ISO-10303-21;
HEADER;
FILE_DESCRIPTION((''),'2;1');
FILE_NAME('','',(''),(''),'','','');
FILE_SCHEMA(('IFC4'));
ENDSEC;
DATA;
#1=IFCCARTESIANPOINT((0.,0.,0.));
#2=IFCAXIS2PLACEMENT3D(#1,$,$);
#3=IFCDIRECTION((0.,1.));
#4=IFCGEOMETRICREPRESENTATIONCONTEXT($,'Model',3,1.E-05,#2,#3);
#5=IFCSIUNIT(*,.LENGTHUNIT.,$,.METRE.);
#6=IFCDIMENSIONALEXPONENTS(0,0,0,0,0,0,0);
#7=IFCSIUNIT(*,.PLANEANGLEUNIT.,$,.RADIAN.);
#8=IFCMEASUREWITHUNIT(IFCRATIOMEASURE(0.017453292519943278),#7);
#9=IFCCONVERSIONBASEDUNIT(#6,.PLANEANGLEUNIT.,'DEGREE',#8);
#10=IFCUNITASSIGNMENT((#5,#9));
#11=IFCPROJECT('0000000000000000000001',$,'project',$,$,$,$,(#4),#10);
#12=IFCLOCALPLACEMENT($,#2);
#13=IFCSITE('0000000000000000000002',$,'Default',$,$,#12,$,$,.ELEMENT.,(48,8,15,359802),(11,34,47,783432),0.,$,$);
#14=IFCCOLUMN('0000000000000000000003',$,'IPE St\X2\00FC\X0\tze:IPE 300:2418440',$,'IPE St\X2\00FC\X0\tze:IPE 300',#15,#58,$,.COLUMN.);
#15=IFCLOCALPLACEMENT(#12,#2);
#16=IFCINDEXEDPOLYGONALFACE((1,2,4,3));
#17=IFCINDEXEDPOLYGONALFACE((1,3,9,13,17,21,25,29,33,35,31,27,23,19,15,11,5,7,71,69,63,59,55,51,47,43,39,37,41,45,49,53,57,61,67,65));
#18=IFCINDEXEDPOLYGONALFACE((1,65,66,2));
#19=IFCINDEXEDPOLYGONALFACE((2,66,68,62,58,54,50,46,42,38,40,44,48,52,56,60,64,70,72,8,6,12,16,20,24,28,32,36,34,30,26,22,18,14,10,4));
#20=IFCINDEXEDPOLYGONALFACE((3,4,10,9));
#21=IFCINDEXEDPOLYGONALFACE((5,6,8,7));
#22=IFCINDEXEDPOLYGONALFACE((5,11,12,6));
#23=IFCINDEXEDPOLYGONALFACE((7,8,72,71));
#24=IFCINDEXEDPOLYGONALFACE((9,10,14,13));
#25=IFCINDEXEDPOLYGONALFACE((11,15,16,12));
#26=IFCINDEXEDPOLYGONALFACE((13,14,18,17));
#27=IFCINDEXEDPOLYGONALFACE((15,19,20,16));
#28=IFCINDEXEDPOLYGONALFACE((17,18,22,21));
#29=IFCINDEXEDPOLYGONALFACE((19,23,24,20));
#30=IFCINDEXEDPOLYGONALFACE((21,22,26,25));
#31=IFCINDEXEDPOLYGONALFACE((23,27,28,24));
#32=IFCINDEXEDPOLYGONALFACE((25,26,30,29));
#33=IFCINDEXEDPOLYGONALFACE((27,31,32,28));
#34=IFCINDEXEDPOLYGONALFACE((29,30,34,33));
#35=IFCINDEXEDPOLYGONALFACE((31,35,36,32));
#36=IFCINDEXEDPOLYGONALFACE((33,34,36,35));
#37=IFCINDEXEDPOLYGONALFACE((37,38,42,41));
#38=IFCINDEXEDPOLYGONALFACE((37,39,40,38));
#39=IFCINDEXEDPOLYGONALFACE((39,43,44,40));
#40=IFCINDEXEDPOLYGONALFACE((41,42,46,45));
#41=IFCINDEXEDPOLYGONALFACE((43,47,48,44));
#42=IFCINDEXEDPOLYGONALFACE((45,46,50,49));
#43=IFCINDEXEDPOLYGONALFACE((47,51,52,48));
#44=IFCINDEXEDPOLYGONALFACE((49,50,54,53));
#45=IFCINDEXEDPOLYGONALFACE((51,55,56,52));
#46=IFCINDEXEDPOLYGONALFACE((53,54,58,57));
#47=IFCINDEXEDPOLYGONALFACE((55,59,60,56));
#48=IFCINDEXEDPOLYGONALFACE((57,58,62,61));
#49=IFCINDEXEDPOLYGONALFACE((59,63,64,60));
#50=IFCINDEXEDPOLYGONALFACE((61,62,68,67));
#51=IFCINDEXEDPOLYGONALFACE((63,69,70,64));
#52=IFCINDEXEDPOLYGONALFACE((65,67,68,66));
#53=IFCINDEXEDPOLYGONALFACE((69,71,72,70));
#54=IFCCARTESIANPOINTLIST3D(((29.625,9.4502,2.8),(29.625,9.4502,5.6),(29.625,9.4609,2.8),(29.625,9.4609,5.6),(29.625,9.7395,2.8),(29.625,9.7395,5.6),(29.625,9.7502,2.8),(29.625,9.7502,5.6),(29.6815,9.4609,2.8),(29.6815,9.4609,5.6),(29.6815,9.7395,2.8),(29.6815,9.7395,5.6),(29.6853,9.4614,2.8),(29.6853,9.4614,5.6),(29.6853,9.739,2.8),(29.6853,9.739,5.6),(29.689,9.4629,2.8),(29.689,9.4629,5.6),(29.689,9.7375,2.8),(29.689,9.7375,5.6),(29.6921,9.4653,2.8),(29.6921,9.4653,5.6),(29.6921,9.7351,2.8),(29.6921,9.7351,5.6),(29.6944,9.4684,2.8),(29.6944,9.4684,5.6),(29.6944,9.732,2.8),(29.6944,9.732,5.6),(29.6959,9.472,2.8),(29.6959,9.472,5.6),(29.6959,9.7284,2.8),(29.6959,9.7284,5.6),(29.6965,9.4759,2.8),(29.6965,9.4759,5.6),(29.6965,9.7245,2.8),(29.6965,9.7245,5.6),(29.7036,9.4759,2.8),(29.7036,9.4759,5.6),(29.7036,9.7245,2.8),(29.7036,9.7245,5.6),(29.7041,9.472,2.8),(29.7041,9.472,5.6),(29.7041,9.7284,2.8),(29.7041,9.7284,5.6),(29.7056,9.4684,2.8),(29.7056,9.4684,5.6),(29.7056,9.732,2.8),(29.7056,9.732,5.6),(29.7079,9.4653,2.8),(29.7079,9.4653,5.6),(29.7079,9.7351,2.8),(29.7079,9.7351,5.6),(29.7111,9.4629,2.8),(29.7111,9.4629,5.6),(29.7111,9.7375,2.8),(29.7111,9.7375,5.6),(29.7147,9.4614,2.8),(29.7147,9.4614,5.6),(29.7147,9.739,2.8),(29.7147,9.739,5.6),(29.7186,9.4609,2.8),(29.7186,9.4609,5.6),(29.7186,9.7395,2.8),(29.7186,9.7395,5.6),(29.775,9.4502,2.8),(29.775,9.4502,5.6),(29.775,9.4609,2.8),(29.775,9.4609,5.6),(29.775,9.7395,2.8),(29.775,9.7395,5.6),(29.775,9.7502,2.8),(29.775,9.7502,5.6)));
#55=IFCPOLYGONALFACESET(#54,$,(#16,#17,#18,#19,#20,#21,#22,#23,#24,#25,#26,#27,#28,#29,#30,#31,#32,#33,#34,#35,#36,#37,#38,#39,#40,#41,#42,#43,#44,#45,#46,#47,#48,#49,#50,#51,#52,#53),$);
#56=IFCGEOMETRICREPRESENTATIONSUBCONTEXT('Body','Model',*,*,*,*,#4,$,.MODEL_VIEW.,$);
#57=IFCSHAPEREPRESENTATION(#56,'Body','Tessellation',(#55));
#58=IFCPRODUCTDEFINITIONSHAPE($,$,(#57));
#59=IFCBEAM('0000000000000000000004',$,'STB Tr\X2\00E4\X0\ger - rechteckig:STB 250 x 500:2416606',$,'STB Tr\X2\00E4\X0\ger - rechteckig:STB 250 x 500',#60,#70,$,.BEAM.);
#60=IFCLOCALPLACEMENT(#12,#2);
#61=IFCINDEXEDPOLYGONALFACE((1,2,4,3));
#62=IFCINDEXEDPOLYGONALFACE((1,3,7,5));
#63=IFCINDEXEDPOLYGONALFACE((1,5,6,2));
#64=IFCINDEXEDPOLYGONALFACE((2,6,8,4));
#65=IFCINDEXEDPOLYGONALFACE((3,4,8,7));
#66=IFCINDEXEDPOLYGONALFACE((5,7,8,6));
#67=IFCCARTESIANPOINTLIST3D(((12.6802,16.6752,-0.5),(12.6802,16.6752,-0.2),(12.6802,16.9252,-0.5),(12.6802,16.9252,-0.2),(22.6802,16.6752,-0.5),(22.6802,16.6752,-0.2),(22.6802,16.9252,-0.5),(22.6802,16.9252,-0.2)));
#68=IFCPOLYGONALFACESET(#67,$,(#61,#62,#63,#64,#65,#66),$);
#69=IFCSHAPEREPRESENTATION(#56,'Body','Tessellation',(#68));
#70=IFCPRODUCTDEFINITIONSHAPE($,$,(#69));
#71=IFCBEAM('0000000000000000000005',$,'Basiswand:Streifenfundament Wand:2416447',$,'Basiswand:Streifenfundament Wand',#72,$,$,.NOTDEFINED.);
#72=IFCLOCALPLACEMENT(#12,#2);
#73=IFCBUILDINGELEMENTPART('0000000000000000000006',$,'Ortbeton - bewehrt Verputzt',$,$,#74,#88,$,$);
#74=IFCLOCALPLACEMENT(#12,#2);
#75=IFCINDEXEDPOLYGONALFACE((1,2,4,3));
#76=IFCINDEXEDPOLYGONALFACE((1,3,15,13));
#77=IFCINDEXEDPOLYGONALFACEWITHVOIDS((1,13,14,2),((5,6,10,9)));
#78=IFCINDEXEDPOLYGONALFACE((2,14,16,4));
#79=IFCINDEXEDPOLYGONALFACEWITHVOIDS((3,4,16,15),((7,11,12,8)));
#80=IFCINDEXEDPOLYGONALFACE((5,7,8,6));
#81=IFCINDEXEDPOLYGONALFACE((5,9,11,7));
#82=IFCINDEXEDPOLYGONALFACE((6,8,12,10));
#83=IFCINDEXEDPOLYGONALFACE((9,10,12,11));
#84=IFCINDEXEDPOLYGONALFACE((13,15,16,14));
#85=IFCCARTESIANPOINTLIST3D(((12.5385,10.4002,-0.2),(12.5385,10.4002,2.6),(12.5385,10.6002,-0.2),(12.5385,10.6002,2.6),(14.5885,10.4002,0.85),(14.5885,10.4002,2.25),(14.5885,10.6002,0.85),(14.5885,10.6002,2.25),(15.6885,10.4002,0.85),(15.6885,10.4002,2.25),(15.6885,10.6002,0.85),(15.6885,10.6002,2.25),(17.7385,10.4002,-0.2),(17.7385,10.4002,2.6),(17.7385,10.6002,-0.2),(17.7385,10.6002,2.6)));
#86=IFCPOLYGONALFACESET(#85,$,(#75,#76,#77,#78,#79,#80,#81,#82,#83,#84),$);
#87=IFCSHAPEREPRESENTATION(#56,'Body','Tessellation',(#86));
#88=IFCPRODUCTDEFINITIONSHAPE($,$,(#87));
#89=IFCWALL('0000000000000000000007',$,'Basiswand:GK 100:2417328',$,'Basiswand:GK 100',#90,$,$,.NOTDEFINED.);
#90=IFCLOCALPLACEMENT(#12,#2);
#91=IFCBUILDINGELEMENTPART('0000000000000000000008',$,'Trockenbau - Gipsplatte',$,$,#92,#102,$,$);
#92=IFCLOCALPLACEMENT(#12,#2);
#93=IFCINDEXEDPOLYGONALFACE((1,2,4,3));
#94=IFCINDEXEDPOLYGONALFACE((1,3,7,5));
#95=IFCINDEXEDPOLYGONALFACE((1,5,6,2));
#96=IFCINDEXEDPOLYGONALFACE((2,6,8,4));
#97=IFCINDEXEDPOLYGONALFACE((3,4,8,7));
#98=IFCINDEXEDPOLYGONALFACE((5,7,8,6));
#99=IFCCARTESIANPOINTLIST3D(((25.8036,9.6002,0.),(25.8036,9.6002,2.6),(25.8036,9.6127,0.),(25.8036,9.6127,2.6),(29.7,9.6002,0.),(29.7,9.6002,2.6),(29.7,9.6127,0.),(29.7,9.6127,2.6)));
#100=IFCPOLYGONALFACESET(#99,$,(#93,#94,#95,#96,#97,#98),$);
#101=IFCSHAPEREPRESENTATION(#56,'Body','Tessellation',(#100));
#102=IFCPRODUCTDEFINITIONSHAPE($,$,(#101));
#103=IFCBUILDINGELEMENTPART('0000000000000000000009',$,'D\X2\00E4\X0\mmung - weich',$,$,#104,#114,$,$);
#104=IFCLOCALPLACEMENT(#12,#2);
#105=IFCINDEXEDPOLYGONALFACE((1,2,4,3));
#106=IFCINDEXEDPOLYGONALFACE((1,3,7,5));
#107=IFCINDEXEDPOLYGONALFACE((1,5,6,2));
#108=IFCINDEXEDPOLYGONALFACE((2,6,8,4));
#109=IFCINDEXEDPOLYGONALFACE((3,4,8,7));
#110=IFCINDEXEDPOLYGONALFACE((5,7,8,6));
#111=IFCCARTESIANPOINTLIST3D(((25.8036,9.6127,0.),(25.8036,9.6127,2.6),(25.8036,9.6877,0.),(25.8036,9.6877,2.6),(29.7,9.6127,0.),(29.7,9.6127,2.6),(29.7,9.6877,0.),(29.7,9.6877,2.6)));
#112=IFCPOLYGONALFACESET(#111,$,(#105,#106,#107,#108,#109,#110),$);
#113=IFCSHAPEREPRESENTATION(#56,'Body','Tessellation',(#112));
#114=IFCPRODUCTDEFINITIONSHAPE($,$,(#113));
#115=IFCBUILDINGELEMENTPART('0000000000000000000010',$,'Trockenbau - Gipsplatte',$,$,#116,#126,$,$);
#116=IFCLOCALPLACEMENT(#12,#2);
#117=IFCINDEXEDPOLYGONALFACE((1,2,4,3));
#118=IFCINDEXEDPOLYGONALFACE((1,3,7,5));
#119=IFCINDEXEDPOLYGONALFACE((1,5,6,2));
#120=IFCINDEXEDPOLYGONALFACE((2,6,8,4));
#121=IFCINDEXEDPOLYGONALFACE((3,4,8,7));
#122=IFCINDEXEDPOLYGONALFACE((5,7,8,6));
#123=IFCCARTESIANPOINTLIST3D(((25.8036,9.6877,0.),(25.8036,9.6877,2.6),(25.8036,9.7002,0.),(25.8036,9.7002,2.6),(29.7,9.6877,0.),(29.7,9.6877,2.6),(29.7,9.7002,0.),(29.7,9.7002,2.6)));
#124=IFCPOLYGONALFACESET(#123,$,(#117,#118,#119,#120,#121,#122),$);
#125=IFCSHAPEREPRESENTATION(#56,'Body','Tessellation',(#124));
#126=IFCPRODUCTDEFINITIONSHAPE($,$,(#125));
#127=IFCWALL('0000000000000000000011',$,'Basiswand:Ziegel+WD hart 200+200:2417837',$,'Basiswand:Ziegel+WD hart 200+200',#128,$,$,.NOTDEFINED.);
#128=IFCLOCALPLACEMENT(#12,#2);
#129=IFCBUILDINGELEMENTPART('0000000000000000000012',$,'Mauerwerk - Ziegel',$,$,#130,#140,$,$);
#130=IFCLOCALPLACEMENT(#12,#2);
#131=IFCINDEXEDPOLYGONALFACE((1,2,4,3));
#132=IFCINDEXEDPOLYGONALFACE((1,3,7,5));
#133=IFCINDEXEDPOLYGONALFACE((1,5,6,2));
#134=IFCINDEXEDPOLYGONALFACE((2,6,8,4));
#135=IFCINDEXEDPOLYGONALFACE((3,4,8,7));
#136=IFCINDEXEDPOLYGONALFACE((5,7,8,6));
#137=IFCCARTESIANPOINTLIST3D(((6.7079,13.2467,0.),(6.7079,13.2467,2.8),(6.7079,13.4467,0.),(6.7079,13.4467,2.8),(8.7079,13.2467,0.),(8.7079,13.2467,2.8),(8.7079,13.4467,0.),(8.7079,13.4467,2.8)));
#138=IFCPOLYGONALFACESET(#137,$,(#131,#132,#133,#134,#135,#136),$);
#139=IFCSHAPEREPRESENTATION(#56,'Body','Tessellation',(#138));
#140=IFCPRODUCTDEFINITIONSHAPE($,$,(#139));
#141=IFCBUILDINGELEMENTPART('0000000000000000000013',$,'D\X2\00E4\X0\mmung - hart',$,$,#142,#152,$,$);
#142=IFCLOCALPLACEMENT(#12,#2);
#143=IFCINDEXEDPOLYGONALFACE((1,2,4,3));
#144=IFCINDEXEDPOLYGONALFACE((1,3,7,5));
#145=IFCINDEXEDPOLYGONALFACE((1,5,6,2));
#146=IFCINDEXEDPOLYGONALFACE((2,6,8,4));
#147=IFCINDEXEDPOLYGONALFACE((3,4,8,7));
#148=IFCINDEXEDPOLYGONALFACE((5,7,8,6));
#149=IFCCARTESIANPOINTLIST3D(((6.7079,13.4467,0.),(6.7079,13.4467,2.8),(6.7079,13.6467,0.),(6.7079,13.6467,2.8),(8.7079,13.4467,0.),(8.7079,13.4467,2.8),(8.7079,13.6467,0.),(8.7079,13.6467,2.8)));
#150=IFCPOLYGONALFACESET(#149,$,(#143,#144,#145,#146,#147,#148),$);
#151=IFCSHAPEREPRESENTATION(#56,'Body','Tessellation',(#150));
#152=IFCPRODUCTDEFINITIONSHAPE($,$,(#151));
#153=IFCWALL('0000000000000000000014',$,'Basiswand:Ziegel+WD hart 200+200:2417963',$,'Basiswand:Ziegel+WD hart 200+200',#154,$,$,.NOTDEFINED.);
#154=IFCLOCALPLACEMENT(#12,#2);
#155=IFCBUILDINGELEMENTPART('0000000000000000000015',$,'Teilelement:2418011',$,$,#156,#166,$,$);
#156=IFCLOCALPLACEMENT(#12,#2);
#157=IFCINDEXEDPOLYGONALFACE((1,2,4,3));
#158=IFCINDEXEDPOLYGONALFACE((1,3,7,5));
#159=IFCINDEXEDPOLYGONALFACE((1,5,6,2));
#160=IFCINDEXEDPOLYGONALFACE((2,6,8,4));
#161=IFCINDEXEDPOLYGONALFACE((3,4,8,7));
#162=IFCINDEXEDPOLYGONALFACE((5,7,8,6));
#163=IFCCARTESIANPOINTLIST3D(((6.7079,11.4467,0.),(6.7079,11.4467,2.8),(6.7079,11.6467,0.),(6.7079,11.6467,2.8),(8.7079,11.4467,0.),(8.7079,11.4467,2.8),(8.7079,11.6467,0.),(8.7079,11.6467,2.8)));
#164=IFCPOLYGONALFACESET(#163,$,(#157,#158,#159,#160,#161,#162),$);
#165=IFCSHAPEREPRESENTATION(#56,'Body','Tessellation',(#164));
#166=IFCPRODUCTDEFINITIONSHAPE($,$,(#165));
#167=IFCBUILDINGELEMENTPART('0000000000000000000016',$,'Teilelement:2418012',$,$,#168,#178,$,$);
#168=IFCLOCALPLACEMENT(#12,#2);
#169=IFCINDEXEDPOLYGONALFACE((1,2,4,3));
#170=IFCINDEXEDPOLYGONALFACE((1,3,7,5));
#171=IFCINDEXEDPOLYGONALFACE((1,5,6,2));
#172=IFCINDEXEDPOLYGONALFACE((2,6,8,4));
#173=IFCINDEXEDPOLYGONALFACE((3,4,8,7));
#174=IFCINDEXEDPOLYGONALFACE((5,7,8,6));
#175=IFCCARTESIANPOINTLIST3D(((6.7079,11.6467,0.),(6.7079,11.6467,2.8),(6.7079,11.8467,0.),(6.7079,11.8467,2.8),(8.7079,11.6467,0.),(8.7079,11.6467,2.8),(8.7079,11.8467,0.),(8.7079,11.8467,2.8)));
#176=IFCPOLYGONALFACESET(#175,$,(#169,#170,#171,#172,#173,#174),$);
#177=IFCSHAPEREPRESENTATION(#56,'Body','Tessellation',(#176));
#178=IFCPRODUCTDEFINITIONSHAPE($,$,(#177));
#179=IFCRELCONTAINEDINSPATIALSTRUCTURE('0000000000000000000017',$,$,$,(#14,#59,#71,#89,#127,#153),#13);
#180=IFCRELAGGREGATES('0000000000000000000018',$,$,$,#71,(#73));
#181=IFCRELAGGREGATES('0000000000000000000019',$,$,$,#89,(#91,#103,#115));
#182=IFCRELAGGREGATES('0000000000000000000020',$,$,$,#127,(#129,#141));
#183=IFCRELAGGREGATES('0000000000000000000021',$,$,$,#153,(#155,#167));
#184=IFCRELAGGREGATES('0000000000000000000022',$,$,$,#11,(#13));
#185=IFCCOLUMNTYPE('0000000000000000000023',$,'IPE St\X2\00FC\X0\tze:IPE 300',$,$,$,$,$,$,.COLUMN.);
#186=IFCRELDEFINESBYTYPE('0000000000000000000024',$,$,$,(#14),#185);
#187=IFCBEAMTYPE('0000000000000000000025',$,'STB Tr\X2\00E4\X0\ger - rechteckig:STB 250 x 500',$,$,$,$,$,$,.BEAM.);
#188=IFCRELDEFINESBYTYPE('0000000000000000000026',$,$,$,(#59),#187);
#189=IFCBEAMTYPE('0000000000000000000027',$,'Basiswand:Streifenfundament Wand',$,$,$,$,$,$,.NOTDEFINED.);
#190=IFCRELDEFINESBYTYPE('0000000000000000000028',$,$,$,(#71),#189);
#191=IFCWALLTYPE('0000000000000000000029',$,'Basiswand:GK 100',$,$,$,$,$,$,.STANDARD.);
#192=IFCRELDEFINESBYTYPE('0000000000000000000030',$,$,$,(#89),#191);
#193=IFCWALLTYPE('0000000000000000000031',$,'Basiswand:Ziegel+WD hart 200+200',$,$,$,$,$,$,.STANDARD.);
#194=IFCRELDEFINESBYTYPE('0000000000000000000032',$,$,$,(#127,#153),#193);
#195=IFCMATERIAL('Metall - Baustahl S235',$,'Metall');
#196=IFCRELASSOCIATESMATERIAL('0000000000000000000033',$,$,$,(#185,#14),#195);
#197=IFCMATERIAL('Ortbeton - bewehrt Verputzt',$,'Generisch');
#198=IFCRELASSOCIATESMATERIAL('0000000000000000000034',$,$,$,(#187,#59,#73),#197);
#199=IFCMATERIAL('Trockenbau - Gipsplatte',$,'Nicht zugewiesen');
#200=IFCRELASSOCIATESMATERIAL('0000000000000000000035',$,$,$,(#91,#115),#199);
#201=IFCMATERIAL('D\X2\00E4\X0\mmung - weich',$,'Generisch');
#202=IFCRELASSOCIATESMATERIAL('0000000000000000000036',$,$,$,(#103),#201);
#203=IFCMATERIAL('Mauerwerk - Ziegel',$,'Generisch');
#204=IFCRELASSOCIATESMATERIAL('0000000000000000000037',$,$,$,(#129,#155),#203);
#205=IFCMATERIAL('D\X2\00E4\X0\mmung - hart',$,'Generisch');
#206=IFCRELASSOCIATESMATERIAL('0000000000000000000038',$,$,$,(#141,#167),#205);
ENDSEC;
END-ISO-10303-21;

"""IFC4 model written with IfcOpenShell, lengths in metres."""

from ifc_helpers import new_model, entity, si_unit, converted_unit, direction, frame, origin, place, context, subcontext, project, spatial, line, arc, indexed_curve, outline, extrude, source, transform, mapped, material, type_object, type_shapes, element, aggregate, save


model = new_model("IFC4")

# Units and contexts
model_context = context("Model", 3, precision=1e-05, world=origin(), true_north=direction((0.0, 1.0)))
body_context = subcontext(model_context, "Body", "Model", "MODEL_VIEW")
ifc_project = project(units=[si_unit("LENGTHUNIT", "METRE"), converted_unit("PLANEANGLEUNIT", "DEGREE", entity("IfcRatioMeasure", 0.017453292519943278), si_unit("PLANEANGLEUNIT", "RADIAN"), dimensions=[0, 0, 0, 0, 0, 0, 0])], contexts=[model_context])

# Site
site_placement = place(None, origin())
site = spatial("IfcSite", under=ifc_project, at=site_placement, Name="Default", CompositionType="ELEMENT", RefLatitude=(48, 8, 15, 359802), RefLongitude=(11, 34, 47, 783432), RefElevation=0.0)

# Shared definitions
ifc_material_1 = material(Name="Ortbeton - bewehrt Verputzt", Category="Generisch")

# Column
ifc_material_2 = material(Name="Metall - Baustahl S235", Category="Metall")
column_type_1 = type_object("IfcColumnType", Name="IPE Stütze:IPE 300", PredefinedType="COLUMN", material=ifc_material_2)
shared_shape_1 = source(origin(), body_context, "Body", "SweptSolid", [
    extrude(outline(indexed_curve([(0.1393, -0.075), (0.15, -0.075), (0.15, 0.075), (0.1393, 0.075), (0.1393, 0.0186), (0.1349, 0.0079), (0.1243, 0.0036), (-0.1243, 0.0036), (-0.1349, 0.0079), (-0.1393, 0.0186), (-0.1393, 0.075), (-0.15, 0.075), (-0.15, -0.075), (-0.1393, -0.075), (-0.1393, -0.0186), (-0.1349, -0.0079), (-0.1243, -0.0035), (0.1243, -0.0036), (0.1349, -0.0079), (0.1393, -0.0185)], segments=[line(1, 2, 3, 4, 5), arc(5, 6, 7), line(7, 8), arc(8, 9, 10), line(10, 11, 12, 13, 14, 15), arc(15, 16, 17), line(17, 18), arc(18, 19, 20), line(20, 1)], self_intersect=False)), frame((0.0, 0.0, 2.8), z_axis=(0.0, 0.0, 1.0), x_axis=(0.0, -1.0, 0.0)), (0.0, 0.0, 1.0), 2.8),
])
type_shapes(column_type_1, [shared_shape_1])
for number, where, name in (
    (1, (29.7, 9.6002, 0.0), "IPE Stütze:IPE 300:2418440"),
):
    element("IfcColumn", number, at=place(site_placement, frame(where)), inside=site, type_object=column_type_1, material=ifc_material_2, Name=name, ObjectType="IPE Stütze:IPE 300", PredefinedType="COLUMN", context=body_context, shape_type="MappedRepresentation", body=[
        mapped(shared_shape_1, transform((0.0, 0.0, 0.0), scale=1.0)),
    ])

# Beam
beam_type_1 = type_object("IfcBeamType", Name="STB Träger - rechteckig:STB 250 x 500", PredefinedType="BEAM", material=ifc_material_1)
shared_shape_2 = source(origin(), body_context, "Body", "SweptSolid", [
    extrude(outline(indexed_curve([(-0.15, -0.125), (0.15, -0.125), (0.15, 0.125), (-0.15, 0.125), (-0.15, -0.125)], self_intersect=False)), frame((12.6802, 16.8002, -0.35), z_axis=(1.0, 0.0, 0.0), x_axis=(0.0, 0.0, -1.0)), (0.0, 0.0, 1.0), 10.0),
])
type_shapes(beam_type_1, [shared_shape_2])
beam_1_placement = place(site_placement, origin())
element("IfcBeam", 2, at=beam_1_placement, inside=site, type_object=beam_type_1, material=ifc_material_1, Name="STB Träger - rechteckig:STB 250 x 500:2416606", ObjectType="STB Träger - rechteckig:STB 250 x 500", PredefinedType="BEAM", context=body_context, shape_type="MappedRepresentation", body=[
    mapped(shared_shape_2, transform((0.0, 0.0, 0.0), scale=1.0)),
])

# Beam, building element part
beam_type_2 = type_object("IfcBeamType", Name="Basiswand:Streifenfundament Wand", PredefinedType="NOTDEFINED")
beam_2_placement = place(site_placement, frame((12.5385, 10.5002, 0.0)))
beam_2 = element("IfcBeam", 3, at=beam_2_placement, inside=site, type_object=beam_type_2, Name="Basiswand:Streifenfundament Wand:2416447", ObjectType="Basiswand:Streifenfundament Wand", PredefinedType="NOTDEFINED")
building_element_part_1_placement = place(beam_2_placement, origin())
building_element_part_1 = element("IfcBuildingElementPart", 4, at=building_element_part_1_placement, material=ifc_material_1, Name="Ortbeton - bewehrt Verputzt", context=body_context, shape_type="SweptSolid", body=[
    extrude(outline(indexed_curve([(-1.4, -2.6), (1.4, -2.6), (1.4, 2.6), (-1.4, 2.6), (-1.4, -2.6)], self_intersect=False), holes=[indexed_curve([(1.05, -0.55), (-0.35, -0.55), (-0.35, 0.55), (1.05, 0.55), (1.05, -0.55)], self_intersect=False)]), frame((2.6, -0.1, 1.2), z_axis=(0.0, 1.0, 0.0), x_axis=(0.0, 0.0, 1.0)), (0.0, 0.0, 1.0), 0.2),
])
aggregate(beam_2, [building_element_part_1])

# Walls, building element parts
wall_type_1 = type_object("IfcWallType", Name="Basiswand:GK 100", PredefinedType="STANDARD")
wall_1_placement = place(site_placement, frame((25.8036, 9.6502, 0.0)))
wall_1 = element("IfcWall", 5, at=wall_1_placement, inside=site, type_object=wall_type_1, Name="Basiswand:GK 100:2417328", ObjectType="Basiswand:GK 100", PredefinedType="NOTDEFINED")
ifc_material_3 = material(Name="Trockenbau - Gipsplatte", Category="Nicht zugewiesen")
building_element_part_2_placement = place(wall_1_placement, origin())
building_element_part_2 = element("IfcBuildingElementPart", 6, at=building_element_part_2_placement, material=ifc_material_3, Name="Trockenbau - Gipsplatte", context=body_context, shape_type="SweptSolid", body=[
    extrude(outline(indexed_curve([(-0.0063, -1.9482), (0.0062, -1.9482), (0.0063, 1.9482), (-0.0062, 1.9482), (-0.0063, -1.9482)], self_intersect=False)), frame((1.9482, -0.0438, 0.0), z_axis=(0.0, 0.0, 1.0), x_axis=(0.0, -1.0, 0.0)), (0.0, 0.0, 1.0), 2.6),
])
ifc_material_4 = material(Name="Dämmung - weich", Category="Generisch")
building_element_part_3_placement = place(wall_1_placement, origin())
building_element_part_3 = element("IfcBuildingElementPart", 7, at=building_element_part_3_placement, material=ifc_material_4, Name="Dämmung - weich", context=body_context, shape_type="SweptSolid", body=[
    extrude(outline(indexed_curve([(-0.0375, -1.9482), (0.0375, -1.9482), (0.0375, 1.9482), (-0.0375, 1.9482), (-0.0375, -1.9482)], self_intersect=False)), frame((1.9482, 0.0, 0.0), z_axis=(0.0, 0.0, 1.0), x_axis=(0.0, -1.0, 0.0)), (0.0, 0.0, 1.0), 2.6),
])
building_element_part_4_placement = place(wall_1_placement, origin())
building_element_part_4 = element("IfcBuildingElementPart", 8, at=building_element_part_4_placement, material=ifc_material_3, Name="Trockenbau - Gipsplatte", context=body_context, shape_type="SweptSolid", body=[
    extrude(outline(indexed_curve([(-0.0063, -1.9482), (0.0062, -1.9482), (0.0063, 1.9482), (-0.0062, 1.9482), (-0.0063, -1.9482)], self_intersect=False)), frame((1.9482, 0.0437, 0.0), z_axis=(0.0, 0.0, 1.0), x_axis=(0.0, -1.0, 0.0)), (0.0, 0.0, 1.0), 2.6),
])
aggregate(wall_1, [building_element_part_2, building_element_part_3, building_element_part_4])
wall_type_2 = type_object("IfcWallType", Name="Basiswand:Ziegel+WD hart 200+200", PredefinedType="STANDARD")
wall_2_placement = place(site_placement, frame((6.7079, 13.4467, 0.0)))
wall_2 = element("IfcWall", 9, at=wall_2_placement, inside=site, type_object=wall_type_2, Name="Basiswand:Ziegel+WD hart 200+200:2417837", ObjectType="Basiswand:Ziegel+WD hart 200+200", PredefinedType="NOTDEFINED")
ifc_material_5 = material(Name="Mauerwerk - Ziegel", Category="Generisch")
building_element_part_5_placement = place(wall_2_placement, origin())
building_element_part_5 = element("IfcBuildingElementPart", 10, at=building_element_part_5_placement, material=ifc_material_5, Name="Mauerwerk - Ziegel", context=body_context, shape_type="SweptSolid", body=[
    extrude(outline(indexed_curve([(-0.1, -1.0), (0.1, -1.0), (0.1, 1.0), (-0.1, 1.0), (-0.1, -1.0)], self_intersect=False)), frame((1.0, -0.1, 0.0), z_axis=(0.0, 0.0, 1.0), x_axis=(0.0, -1.0, 0.0)), (0.0, 0.0, 1.0), 2.8),
])
ifc_material_6 = material(Name="Dämmung - hart", Category="Generisch")
building_element_part_6_placement = place(wall_2_placement, origin())
building_element_part_6 = element("IfcBuildingElementPart", 11, at=building_element_part_6_placement, material=ifc_material_6, Name="Dämmung - hart", context=body_context, shape_type="SweptSolid", body=[
    extrude(outline(indexed_curve([(-0.1, -1.0), (0.1, -1.0), (0.1, 1.0), (-0.1, 1.0), (-0.1, -1.0)], self_intersect=False)), frame((1.0, 0.1, 0.0), z_axis=(0.0, 0.0, 1.0), x_axis=(0.0, -1.0, 0.0)), (0.0, 0.0, 1.0), 2.8),
])
aggregate(wall_2, [building_element_part_5, building_element_part_6])
wall_3_placement = place(site_placement, frame((6.7079, 11.6467, 0.0)))
wall_3 = element("IfcWall", 12, at=wall_3_placement, inside=site, type_object=wall_type_2, Name="Basiswand:Ziegel+WD hart 200+200:2417963", ObjectType="Basiswand:Ziegel+WD hart 200+200", PredefinedType="NOTDEFINED")
building_element_part_7_placement = place(wall_3_placement, origin())
building_element_part_7 = element("IfcBuildingElementPart", 13, at=building_element_part_7_placement, material=ifc_material_5, Name="Teilelement:2418011", context=body_context, shape_type="SweptSolid", body=[
    extrude(outline(indexed_curve([(-0.1, -1.0), (0.1, -1.0), (0.1, 1.0), (-0.1, 1.0), (-0.1, -1.0)], self_intersect=False)), frame((1.0, -0.1, 0.0), z_axis=(0.0, 0.0, 1.0), x_axis=(0.0, -1.0, 0.0)), (0.0, 0.0, 1.0), 2.8),
])
building_element_part_8_placement = place(wall_3_placement, origin())
building_element_part_8 = element("IfcBuildingElementPart", 14, at=building_element_part_8_placement, material=ifc_material_6, Name="Teilelement:2418012", context=body_context, shape_type="SweptSolid", body=[
    extrude(outline(indexed_curve([(-0.1, -1.0), (0.1, -1.0), (0.1, 1.0), (-0.1, 1.0), (-0.1, -1.0)], self_intersect=False)), frame((1.0, 0.1, 0.0), z_axis=(0.0, 0.0, 1.0), x_axis=(0.0, -1.0, 0.0)), (0.0, 0.0, 1.0), 2.8),
])
aggregate(wall_3, [building_element_part_7, building_element_part_8])

save(model, "model.ifc")
